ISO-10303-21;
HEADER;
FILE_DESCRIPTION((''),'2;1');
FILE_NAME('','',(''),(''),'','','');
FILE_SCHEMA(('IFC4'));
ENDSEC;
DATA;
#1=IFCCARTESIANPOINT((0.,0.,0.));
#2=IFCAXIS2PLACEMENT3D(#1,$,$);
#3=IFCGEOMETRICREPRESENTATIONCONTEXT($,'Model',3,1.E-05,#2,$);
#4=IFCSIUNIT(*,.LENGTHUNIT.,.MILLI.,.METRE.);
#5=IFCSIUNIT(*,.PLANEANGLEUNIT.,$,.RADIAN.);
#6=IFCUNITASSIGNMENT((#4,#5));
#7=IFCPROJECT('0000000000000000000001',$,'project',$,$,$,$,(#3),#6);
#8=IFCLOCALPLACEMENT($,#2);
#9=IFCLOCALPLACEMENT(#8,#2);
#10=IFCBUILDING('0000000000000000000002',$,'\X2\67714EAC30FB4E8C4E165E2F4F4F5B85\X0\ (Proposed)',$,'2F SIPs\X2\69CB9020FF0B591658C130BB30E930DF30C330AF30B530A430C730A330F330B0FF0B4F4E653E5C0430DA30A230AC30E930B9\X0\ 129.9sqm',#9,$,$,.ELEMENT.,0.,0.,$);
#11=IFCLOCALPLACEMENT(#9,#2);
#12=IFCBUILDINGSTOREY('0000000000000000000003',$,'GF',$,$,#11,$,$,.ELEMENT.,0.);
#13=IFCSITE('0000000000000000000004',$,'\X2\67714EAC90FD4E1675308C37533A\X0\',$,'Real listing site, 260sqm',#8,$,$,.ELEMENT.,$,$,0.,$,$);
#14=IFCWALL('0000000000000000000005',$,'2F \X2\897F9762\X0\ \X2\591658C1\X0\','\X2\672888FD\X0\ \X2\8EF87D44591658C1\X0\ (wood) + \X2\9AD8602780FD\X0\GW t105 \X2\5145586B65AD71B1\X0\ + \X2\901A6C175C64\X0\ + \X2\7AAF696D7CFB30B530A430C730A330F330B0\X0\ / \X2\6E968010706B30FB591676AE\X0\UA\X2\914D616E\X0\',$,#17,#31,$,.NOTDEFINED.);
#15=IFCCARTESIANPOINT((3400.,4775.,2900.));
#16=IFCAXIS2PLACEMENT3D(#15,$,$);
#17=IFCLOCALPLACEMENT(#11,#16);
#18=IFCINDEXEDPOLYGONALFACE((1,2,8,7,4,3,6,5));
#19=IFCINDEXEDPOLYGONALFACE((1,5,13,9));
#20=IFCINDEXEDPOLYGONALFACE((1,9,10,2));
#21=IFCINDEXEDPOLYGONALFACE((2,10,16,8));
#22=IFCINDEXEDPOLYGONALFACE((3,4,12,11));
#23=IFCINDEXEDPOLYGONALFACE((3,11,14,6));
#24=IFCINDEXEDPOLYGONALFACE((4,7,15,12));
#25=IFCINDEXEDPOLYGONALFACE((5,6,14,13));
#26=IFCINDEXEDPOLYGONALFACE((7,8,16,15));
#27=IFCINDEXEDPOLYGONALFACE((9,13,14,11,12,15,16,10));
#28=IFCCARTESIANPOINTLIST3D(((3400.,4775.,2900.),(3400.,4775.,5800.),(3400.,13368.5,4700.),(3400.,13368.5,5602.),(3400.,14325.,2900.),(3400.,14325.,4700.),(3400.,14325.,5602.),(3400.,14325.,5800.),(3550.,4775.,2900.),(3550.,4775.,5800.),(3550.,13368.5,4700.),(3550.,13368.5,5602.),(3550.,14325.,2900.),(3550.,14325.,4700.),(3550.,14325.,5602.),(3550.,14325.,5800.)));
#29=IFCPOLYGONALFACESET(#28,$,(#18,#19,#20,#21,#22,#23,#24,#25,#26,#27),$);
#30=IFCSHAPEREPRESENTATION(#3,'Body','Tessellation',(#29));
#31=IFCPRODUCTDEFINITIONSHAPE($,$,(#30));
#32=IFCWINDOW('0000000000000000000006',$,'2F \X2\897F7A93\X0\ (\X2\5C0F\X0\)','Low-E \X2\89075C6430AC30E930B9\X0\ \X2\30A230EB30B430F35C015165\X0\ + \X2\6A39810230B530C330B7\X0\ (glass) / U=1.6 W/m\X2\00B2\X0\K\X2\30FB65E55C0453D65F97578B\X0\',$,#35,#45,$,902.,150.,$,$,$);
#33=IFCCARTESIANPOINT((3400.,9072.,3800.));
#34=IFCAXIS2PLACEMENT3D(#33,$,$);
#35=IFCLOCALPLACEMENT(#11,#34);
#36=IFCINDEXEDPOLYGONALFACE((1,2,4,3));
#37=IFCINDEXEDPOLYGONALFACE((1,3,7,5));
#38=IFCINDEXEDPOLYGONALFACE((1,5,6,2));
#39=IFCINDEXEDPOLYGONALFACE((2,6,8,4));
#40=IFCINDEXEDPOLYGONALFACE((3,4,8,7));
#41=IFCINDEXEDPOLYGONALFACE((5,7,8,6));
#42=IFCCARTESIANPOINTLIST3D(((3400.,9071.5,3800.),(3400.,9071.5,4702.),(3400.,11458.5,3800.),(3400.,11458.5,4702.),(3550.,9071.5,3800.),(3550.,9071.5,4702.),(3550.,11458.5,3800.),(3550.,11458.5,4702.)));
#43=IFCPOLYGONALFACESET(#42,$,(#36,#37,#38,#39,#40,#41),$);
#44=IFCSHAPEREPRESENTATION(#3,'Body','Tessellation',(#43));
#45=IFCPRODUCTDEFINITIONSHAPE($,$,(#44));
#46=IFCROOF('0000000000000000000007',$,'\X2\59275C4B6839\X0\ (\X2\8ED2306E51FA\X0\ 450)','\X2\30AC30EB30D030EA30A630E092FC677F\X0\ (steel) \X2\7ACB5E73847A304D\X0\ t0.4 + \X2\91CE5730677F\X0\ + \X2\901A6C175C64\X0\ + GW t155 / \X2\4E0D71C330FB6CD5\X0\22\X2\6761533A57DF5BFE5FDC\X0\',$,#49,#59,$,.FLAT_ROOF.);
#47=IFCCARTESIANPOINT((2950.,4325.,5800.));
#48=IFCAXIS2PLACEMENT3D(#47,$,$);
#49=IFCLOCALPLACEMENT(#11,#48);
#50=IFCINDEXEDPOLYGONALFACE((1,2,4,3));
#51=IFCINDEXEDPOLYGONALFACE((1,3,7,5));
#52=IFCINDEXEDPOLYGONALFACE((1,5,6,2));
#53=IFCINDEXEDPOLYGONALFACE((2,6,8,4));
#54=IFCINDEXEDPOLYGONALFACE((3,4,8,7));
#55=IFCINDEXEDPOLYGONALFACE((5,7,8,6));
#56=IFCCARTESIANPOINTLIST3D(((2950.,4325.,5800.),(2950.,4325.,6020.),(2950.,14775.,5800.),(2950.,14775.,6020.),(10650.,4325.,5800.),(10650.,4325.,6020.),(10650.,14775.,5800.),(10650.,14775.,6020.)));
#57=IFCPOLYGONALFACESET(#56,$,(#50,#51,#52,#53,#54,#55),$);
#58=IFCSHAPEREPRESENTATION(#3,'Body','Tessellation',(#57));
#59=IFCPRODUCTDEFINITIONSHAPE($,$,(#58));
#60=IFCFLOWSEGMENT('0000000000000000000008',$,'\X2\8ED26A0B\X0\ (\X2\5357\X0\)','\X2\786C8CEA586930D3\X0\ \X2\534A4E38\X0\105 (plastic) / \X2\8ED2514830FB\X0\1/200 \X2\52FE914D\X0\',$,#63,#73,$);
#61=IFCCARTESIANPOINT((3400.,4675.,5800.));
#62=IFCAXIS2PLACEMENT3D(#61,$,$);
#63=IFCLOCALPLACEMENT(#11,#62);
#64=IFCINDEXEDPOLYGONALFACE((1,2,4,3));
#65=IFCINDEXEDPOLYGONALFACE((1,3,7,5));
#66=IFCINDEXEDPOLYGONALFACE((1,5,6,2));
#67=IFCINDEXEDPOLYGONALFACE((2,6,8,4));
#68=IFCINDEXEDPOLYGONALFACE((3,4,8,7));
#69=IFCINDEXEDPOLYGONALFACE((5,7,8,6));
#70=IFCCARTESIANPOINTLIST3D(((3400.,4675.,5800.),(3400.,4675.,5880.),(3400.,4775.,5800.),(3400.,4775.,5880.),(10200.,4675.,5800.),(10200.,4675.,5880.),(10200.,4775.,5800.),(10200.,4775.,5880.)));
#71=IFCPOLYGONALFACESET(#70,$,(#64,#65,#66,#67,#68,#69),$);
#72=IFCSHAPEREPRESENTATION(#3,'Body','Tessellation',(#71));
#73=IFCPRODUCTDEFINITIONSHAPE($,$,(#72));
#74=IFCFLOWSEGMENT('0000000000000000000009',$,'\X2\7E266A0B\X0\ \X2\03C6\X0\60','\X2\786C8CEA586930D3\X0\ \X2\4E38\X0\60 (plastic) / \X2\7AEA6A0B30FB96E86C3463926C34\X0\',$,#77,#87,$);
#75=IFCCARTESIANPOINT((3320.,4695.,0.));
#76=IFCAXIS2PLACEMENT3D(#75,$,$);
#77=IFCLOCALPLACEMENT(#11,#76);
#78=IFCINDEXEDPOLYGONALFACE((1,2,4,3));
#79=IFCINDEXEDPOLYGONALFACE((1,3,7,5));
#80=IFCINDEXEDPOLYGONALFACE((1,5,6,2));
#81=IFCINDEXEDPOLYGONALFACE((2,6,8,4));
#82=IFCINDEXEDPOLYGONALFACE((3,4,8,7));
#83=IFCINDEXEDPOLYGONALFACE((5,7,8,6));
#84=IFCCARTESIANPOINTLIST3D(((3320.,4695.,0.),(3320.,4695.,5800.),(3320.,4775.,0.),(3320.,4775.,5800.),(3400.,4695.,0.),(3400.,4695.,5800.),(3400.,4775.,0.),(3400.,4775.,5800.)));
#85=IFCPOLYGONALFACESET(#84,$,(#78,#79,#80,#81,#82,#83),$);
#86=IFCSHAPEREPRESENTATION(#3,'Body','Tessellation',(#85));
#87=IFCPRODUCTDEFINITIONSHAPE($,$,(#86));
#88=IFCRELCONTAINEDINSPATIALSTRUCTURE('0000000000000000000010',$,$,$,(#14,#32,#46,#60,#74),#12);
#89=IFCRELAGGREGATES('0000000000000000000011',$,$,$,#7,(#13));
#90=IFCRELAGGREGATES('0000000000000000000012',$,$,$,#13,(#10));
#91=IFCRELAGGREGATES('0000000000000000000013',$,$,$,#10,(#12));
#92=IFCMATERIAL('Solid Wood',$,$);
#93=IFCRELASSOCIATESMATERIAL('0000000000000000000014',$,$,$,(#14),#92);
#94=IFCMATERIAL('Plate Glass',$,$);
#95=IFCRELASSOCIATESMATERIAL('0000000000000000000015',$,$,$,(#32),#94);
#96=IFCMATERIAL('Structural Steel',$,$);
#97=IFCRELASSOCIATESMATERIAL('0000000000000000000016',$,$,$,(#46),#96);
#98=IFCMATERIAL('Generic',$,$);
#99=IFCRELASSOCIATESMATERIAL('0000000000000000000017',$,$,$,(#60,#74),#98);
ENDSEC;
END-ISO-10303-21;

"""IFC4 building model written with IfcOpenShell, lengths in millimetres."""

from ifc_helpers import new_model, si_unit, frame, frame_2d, origin, place, context, project, spatial, rectangle, extrude, material, element, fill, save


model = new_model("IFC4")

# Units and contexts
model_context = context("Model", 3, precision=1e-05, world=origin())
ifc_project = project(units=[si_unit("LENGTHUNIT", "METRE", prefix="MILLI"), si_unit("PLANEANGLEUNIT", "RADIAN")], contexts=[model_context])

# Site, building, storey
site_placement = place(None, origin())
site = spatial("IfcSite", under=ifc_project, at=site_placement, Name="東京都世田谷区", ObjectType="Real listing site, 260sqm", CompositionType="ELEMENT", RefElevation=0.0)
building_placement = place(site_placement, origin())
building = spatial("IfcBuilding", under=site, at=building_placement, Name="東京・二世帯住宅 (Proposed)", ObjectType="2F SIPs構造＋外壁セラミックサイディング＋低放射ペアガラス 129.9sqm", CompositionType="ELEMENT", ElevationOfRefHeight=0.0, ElevationOfTerrain=0.0)
storey_placement = place(building_placement, origin())
storey = spatial("IfcBuildingStorey", under=building, at=storey_placement, Name="GF", CompositionType="ELEMENT", Elevation=0.0)

# Shared definitions
ifc_material_1 = material(Name="Solid Wood")

# Shared definitions
ifc_material_2 = material(Name="Plate Glass")

# Wall, opening, window
wall_1_placement = place(storey_placement, frame((3400.0, 4775.0, 2900.0)))
wall_1 = element("IfcWall", 1, at=wall_1_placement, inside=storey, material=ifc_material_1, Name="2F 西面 外壁", Description="木製 軸組外壁 (wood) + 高性能GW t105 充填断熱 + 通気層 + 窯業系サイディング / 準耐火・外皮UA配慮", PredefinedType="NOTDEFINED", context=model_context, shape_type="SweptSolid", body=[
    extrude(rectangle(XDim=150.0, YDim=9550.0, at=frame_2d((75.0, 4775.0))), frame((3400.0, 4775.0, 2900.0)), (0.0, 0.0, 1.0), 2900.0),
])
opening_1_placement = place(storey_placement, frame((3400.0, 9072.0, 3800.0)))
opening_1 = element("IfcOpeningElement", 2, at=opening_1_placement, cuts=wall_1, PredefinedType="NOTDEFINED", context=model_context, shape_type="SweptSolid", body=[
    extrude(rectangle(XDim=150.0, YDim=2387.0, at=frame_2d((75.0, 1193.0))), frame((3400.0, 9072.0, 3800.0)), (0.0, 0.0, 1.0), 902.0),
])
window_1_placement = place(storey_placement, frame((3400.0, 9072.0, 3800.0)))
window_1 = element("IfcWindow", 3, at=window_1_placement, inside=storey, material=ifc_material_2, Name="2F 西窓 (小)", Description="Low-E 複層ガラス アルゴン封入 + 樹脂サッシ (glass) / U=1.6 W/m²K・日射取得型", OverallHeight=902.0, OverallWidth=150.0, context=model_context, shape_type="SweptSolid", body=[
    extrude(rectangle(XDim=150.0, YDim=2387.0, at=frame_2d((75.0, 1193.0))), frame((3400.0, 9072.0, 3800.0)), (0.0, 0.0, 1.0), 902.0),
])
fill(opening_1, window_1)

# Roof
ifc_material_3 = material(Name="Structural Steel")
roof_placement = place(storey_placement, frame((2950.0, 4325.0, 5800.0)))
element("IfcRoof", 4, at=roof_placement, inside=storey, material=ifc_material_3, Name="大屋根 (軒の出 450)", Description="ガルバリウム鋼板 (steel) 立平葺き t0.4 + 野地板 + 通気層 + GW t155 / 不燃・法22条区域対応", PredefinedType="FLAT_ROOF", context=model_context, shape_type="SweptSolid", body=[
    extrude(rectangle(XDim=7700.0, YDim=10450.0, at=frame_2d((3850.0, 5225.0))), frame((2950.0, 4325.0, 5800.0)), (0.0, 0.0, 1.0), 220.0),
])

# Flow segments
ifc_material_4 = material(Name="Generic")
flow_segment_1_placement = place(storey_placement, frame((3400.0, 4675.0, 5800.0)))
element("IfcFlowSegment", 5, at=flow_segment_1_placement, inside=storey, material=ifc_material_4, Name="軒樋 (南)", Description="硬質塩ビ 半丸105 (plastic) / 軒先・1/200 勾配", context=model_context, shape_type="SweptSolid", body=[
    extrude(rectangle(XDim=6800.0, YDim=100.0, at=frame_2d((3400.0, 50.0))), frame((3400.0, 4675.0, 5800.0)), (0.0, 0.0, 1.0), 80.0),
])
flow_segment_2_placement = place(storey_placement, frame((3320.0, 4695.0, 0.0)))
element("IfcFlowSegment", 6, at=flow_segment_2_placement, inside=storey, material=ifc_material_4, Name="縦樋 φ60", Description="硬質塩ビ 丸60 (plastic) / 竪樋・雨水排水", context=model_context, shape_type="SweptSolid", body=[
    extrude(rectangle(XDim=80.0, YDim=80.0, at=frame_2d((40.0, 40.0))), frame((3320.0, 4695.0, 0.0)), (0.0, 0.0, 1.0), 5800.0),
])

save(model, "model.ifc")
